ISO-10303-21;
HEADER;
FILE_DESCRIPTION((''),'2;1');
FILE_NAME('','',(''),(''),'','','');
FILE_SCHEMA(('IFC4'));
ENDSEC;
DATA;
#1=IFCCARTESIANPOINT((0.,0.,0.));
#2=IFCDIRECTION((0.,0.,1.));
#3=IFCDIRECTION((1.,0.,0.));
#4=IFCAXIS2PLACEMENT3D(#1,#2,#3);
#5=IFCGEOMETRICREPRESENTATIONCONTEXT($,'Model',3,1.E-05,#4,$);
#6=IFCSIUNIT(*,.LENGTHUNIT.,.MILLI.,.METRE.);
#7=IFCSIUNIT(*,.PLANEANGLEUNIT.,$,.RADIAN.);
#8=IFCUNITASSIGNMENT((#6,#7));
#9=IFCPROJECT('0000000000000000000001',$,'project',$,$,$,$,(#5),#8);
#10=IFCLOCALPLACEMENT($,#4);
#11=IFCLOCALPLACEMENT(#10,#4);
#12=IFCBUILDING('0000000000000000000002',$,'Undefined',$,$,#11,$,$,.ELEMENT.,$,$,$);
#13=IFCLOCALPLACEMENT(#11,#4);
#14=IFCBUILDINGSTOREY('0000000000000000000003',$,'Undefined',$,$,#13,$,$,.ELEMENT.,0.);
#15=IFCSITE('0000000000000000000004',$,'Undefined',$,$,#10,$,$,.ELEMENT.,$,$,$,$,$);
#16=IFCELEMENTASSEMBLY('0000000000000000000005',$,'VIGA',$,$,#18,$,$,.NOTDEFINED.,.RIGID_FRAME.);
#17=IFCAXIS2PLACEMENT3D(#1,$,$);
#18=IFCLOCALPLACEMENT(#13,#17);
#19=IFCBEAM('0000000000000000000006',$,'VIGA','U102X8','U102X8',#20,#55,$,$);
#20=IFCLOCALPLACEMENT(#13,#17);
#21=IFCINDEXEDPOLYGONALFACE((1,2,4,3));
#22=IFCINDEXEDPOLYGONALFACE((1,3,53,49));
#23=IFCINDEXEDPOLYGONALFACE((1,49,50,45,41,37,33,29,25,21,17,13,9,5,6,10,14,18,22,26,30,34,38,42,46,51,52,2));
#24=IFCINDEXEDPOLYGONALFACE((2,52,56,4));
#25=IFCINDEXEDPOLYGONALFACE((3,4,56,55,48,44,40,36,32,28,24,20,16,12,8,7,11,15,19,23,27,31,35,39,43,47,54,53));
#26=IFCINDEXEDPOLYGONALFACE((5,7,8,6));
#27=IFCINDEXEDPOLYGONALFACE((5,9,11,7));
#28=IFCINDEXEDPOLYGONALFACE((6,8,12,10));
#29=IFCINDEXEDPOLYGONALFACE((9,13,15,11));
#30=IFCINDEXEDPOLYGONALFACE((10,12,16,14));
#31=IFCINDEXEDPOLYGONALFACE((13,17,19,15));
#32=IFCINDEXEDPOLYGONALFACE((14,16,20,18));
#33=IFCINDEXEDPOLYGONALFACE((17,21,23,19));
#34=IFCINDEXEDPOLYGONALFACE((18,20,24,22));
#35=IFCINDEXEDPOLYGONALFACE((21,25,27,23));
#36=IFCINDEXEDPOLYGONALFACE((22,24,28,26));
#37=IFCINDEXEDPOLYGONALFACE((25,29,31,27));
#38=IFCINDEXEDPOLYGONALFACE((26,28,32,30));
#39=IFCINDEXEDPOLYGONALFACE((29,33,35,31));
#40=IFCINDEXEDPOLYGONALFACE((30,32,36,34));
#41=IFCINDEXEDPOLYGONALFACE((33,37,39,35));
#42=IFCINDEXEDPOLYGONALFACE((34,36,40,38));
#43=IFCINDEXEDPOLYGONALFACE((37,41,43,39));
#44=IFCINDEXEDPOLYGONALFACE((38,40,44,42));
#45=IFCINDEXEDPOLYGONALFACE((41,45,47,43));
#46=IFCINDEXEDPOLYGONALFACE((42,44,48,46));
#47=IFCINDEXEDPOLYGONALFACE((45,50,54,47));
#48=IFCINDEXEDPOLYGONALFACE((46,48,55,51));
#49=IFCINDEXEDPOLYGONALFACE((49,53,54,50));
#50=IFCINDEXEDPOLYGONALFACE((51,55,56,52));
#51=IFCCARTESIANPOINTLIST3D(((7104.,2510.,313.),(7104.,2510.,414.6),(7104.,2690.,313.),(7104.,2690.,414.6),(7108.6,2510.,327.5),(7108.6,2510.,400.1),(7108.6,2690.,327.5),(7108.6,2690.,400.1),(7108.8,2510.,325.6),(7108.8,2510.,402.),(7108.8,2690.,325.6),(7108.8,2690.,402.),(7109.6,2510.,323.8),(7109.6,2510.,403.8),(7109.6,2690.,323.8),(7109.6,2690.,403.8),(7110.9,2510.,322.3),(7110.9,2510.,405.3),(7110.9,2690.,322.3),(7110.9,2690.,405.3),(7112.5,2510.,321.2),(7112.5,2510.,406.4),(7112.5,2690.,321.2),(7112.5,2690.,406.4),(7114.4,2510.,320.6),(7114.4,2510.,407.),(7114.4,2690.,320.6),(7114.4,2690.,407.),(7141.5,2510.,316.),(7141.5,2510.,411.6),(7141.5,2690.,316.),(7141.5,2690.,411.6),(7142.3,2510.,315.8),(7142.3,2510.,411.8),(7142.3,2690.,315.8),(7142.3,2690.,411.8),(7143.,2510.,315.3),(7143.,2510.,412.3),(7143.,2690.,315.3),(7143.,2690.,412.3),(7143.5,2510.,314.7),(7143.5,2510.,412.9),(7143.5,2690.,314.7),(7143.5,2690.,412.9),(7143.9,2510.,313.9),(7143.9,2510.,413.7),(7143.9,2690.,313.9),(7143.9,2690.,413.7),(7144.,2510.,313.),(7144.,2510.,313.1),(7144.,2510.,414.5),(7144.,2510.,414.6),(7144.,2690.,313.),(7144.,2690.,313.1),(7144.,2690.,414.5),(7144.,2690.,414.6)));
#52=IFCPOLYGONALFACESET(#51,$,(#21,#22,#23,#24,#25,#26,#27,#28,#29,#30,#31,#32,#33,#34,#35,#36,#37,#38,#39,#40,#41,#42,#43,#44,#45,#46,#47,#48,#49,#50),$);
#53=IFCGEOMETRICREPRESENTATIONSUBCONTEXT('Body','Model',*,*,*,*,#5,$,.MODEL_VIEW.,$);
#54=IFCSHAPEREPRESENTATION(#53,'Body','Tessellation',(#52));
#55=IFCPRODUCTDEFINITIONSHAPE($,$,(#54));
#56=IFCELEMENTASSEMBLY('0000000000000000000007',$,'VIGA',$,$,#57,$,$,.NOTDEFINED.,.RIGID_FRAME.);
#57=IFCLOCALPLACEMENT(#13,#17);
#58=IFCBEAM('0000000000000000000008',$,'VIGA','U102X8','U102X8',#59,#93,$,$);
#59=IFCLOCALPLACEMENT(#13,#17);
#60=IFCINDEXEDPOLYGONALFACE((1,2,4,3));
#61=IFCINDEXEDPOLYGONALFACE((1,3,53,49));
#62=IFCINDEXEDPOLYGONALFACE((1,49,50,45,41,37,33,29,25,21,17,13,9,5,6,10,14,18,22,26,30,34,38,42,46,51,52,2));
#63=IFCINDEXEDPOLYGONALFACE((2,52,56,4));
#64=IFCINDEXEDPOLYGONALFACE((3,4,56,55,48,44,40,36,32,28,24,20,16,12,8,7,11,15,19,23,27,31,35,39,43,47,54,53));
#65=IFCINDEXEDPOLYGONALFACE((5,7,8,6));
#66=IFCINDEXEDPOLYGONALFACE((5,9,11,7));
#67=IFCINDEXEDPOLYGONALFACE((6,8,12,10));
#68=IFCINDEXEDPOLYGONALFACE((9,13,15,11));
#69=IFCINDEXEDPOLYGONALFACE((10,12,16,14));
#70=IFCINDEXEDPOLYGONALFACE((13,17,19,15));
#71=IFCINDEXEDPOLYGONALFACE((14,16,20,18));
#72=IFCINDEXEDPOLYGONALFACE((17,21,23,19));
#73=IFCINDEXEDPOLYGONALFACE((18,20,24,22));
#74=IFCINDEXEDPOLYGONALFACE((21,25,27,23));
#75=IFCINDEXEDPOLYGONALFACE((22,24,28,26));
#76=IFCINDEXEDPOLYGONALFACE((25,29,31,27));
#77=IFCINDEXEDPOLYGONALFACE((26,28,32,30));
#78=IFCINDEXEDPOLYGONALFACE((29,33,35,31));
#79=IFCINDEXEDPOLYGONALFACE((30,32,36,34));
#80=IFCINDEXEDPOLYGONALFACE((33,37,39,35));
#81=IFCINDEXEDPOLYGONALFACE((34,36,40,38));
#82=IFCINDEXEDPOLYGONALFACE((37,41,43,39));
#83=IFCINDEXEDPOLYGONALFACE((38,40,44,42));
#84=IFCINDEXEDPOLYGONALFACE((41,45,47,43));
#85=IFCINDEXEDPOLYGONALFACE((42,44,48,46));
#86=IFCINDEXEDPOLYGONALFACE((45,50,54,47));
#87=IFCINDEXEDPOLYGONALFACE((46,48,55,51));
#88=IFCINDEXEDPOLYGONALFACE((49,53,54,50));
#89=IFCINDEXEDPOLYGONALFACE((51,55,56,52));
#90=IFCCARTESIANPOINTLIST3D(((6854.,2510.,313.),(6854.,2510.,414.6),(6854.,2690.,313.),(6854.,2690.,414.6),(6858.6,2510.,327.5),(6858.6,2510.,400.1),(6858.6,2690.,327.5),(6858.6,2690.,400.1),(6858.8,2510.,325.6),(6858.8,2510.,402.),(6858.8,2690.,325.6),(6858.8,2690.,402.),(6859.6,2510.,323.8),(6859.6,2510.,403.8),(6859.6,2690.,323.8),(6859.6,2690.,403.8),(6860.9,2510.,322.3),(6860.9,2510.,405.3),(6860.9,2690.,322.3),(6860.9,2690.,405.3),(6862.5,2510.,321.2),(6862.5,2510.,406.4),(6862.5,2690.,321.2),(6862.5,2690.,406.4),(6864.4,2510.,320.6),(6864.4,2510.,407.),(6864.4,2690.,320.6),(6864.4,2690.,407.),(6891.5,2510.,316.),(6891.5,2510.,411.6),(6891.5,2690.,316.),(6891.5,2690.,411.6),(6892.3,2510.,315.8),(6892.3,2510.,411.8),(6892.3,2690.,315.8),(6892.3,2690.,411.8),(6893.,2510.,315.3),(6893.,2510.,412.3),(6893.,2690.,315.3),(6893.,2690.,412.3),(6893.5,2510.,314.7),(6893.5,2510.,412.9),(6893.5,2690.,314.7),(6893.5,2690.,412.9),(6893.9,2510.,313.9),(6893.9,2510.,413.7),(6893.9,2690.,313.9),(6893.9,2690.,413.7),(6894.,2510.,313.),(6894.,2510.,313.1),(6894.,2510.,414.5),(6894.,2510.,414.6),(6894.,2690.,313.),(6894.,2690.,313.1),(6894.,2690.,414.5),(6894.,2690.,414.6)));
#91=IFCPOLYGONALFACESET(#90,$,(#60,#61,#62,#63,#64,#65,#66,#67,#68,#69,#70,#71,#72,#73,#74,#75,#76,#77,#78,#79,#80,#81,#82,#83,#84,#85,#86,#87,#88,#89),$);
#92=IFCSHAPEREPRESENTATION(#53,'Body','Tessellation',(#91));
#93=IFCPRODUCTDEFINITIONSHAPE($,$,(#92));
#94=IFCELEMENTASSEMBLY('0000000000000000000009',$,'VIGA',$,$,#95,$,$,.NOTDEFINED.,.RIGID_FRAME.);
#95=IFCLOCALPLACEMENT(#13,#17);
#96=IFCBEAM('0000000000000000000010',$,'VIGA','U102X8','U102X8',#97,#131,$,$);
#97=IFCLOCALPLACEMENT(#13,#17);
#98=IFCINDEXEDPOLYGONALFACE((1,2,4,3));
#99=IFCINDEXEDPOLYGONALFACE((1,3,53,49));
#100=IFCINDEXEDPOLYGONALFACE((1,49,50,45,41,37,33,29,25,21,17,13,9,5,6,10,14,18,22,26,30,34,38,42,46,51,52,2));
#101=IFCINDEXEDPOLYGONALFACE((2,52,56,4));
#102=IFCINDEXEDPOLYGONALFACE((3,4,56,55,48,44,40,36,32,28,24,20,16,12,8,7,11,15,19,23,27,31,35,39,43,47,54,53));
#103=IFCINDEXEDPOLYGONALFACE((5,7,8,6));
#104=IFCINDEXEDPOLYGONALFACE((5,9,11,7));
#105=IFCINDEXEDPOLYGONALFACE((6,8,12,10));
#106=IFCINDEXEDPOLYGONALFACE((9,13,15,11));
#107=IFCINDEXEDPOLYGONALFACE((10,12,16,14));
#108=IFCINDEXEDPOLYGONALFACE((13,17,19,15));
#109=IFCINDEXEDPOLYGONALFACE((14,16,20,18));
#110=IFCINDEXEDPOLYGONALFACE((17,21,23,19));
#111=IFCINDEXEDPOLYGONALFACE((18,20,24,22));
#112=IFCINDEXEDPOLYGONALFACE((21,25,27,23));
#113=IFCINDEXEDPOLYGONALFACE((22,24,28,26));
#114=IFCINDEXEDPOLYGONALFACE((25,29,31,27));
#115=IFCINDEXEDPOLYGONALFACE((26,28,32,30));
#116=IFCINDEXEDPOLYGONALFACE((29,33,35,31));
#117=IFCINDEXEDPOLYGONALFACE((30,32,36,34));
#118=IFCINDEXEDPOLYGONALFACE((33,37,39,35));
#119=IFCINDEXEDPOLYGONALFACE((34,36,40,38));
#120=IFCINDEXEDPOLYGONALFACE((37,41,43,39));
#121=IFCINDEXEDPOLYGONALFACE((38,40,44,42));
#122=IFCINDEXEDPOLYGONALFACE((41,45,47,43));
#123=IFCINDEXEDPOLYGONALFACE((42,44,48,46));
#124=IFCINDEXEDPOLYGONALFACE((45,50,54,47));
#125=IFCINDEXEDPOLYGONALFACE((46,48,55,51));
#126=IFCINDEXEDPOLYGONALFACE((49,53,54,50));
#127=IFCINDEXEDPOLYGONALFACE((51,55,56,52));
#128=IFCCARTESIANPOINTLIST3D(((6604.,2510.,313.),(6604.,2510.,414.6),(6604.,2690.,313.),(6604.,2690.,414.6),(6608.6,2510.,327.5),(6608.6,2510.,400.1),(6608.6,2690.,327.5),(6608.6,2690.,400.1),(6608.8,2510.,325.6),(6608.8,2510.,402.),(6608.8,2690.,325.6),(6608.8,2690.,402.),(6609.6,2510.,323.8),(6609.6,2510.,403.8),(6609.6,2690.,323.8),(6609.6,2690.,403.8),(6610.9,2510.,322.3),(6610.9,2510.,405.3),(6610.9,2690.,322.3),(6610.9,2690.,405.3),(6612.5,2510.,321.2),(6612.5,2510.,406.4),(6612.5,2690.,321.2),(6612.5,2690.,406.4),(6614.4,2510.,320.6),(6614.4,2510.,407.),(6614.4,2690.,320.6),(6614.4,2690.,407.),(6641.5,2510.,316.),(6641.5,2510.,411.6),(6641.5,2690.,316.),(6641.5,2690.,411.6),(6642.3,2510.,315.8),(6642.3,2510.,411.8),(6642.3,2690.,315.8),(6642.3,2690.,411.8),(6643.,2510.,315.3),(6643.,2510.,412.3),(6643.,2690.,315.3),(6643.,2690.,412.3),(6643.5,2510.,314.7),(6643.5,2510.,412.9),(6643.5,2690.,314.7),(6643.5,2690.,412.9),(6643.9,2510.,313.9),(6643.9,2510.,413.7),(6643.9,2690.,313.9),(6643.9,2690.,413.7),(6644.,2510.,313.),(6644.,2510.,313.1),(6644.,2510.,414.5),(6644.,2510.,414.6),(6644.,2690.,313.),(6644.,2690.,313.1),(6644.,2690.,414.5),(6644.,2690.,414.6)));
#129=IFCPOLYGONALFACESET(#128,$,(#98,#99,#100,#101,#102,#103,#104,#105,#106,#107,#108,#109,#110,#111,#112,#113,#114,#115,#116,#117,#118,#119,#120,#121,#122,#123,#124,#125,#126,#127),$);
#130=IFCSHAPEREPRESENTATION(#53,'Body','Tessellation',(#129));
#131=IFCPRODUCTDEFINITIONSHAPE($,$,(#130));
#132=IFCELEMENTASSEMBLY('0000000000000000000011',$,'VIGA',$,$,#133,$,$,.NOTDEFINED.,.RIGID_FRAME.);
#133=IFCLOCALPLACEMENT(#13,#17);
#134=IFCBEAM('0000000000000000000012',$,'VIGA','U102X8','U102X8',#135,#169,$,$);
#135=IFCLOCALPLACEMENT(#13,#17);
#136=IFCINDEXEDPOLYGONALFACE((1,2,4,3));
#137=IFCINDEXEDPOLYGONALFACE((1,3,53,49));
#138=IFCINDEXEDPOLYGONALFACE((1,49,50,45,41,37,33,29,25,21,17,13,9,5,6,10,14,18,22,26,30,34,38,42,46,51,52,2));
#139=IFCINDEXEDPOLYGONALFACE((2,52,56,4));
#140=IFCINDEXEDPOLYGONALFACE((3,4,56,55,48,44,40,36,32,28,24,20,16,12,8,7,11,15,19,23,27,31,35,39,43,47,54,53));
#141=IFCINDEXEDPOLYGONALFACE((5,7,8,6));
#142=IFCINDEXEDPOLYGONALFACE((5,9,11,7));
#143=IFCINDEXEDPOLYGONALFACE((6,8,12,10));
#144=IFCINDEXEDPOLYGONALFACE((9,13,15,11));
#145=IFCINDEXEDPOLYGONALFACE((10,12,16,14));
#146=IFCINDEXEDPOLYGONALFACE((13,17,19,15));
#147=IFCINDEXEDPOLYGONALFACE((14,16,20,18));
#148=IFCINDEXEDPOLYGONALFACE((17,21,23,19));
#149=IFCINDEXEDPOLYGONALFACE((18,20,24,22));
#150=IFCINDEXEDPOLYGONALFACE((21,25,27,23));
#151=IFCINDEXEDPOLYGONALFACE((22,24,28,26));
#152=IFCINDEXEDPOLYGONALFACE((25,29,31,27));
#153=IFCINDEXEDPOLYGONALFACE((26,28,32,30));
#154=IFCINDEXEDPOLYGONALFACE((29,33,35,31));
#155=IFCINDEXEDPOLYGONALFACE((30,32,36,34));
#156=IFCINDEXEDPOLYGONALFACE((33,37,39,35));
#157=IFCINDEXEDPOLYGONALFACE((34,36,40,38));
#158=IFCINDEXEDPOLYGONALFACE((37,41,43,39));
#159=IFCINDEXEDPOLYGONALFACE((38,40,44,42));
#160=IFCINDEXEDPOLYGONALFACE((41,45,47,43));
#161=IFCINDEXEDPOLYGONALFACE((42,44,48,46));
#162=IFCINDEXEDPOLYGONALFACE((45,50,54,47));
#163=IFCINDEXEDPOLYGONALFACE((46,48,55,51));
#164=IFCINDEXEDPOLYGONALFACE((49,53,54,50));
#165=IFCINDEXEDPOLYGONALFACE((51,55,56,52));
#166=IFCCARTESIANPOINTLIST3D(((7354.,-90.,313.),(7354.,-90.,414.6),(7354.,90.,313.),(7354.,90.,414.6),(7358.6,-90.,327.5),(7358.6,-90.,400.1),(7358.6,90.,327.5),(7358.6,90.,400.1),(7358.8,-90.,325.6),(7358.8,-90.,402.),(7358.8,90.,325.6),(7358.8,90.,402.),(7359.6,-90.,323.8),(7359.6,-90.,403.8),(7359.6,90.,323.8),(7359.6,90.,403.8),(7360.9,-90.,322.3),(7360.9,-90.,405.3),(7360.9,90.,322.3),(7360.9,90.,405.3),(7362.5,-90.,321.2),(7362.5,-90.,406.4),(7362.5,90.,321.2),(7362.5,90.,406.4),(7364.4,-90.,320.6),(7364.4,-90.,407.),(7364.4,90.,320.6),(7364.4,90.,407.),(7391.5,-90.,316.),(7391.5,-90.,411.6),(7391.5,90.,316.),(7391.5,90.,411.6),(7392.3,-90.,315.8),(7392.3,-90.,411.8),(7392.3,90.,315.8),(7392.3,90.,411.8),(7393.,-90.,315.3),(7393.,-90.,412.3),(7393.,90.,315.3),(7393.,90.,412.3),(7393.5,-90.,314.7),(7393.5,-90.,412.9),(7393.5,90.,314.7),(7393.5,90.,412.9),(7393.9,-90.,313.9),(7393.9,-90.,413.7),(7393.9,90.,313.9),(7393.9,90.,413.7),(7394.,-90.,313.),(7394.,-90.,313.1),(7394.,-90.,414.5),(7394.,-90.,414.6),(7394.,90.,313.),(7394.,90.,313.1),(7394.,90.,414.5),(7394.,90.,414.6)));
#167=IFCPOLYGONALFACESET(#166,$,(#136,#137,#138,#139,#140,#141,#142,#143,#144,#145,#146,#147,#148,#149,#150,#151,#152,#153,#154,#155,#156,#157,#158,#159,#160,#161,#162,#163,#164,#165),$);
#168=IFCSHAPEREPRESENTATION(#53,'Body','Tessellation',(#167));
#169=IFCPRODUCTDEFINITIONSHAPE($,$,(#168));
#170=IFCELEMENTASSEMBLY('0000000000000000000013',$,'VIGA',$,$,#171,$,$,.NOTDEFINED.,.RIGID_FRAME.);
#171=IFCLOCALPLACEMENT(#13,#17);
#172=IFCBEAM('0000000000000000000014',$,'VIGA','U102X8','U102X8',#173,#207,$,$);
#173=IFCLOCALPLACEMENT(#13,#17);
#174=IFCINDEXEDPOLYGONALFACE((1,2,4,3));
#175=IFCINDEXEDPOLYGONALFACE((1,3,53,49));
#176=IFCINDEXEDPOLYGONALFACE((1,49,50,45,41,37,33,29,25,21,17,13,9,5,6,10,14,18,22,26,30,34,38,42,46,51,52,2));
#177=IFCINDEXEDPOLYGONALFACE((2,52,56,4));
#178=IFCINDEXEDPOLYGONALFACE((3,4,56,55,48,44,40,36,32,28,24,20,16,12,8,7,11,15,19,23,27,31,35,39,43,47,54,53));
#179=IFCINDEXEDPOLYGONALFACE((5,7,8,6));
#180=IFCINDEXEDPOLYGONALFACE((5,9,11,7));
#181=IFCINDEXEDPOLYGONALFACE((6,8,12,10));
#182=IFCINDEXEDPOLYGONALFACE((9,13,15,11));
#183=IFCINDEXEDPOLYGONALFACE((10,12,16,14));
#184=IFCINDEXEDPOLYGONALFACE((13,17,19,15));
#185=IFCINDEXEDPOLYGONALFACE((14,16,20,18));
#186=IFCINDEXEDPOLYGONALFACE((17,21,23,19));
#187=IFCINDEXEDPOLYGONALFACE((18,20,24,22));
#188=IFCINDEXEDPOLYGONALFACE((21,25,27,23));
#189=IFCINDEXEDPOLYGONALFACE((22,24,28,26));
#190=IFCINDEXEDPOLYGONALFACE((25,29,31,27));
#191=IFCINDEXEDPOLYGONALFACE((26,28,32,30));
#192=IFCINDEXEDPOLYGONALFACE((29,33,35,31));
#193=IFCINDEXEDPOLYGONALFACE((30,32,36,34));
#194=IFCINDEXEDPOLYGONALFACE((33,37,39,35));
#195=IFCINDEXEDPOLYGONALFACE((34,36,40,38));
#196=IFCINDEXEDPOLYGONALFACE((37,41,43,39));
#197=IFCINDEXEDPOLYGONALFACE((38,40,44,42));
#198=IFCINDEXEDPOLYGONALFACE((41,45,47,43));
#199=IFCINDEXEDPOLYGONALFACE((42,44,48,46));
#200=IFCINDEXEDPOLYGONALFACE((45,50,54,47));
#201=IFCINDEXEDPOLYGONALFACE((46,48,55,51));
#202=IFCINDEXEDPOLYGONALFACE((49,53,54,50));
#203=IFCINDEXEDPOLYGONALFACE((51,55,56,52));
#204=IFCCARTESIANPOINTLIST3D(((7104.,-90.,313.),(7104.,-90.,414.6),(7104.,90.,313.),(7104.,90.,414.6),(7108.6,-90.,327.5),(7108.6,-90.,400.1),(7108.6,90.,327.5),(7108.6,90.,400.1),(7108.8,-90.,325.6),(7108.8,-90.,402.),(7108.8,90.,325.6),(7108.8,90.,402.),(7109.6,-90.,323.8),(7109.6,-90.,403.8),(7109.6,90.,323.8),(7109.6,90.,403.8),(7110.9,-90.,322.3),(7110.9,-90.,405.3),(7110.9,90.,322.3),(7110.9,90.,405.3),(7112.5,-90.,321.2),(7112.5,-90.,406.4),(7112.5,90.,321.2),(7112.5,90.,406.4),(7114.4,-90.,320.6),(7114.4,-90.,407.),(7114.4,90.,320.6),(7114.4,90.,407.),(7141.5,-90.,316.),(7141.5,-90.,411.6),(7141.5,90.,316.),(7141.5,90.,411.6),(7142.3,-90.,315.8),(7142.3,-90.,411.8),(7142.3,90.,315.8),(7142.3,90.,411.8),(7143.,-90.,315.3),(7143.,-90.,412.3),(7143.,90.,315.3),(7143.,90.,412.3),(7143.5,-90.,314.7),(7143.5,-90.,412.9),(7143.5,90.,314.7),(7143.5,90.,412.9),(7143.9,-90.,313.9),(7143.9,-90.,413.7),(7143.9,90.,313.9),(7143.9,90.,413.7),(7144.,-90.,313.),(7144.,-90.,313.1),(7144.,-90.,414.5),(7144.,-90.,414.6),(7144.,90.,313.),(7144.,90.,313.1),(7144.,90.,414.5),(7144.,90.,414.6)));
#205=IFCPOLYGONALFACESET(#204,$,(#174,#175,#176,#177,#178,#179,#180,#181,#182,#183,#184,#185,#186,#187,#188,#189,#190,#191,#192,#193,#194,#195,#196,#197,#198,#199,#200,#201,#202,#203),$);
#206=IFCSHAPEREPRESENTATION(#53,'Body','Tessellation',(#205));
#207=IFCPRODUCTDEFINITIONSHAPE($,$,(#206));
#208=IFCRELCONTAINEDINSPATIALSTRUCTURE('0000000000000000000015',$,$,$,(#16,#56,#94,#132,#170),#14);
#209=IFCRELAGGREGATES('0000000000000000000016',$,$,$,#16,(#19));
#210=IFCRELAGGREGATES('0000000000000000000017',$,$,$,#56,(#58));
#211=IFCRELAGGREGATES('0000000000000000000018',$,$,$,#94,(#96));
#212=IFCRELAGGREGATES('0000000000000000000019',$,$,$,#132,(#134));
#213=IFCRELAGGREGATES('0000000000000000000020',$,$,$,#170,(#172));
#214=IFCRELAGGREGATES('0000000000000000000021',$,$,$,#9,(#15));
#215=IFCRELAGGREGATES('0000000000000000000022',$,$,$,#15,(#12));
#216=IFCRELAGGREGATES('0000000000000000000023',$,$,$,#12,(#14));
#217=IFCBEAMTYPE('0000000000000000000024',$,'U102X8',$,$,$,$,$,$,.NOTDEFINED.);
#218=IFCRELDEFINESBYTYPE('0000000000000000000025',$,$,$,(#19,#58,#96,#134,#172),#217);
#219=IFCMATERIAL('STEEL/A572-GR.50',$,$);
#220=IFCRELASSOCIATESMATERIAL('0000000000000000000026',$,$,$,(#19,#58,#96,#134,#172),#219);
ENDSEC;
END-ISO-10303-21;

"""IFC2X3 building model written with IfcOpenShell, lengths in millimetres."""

from ifc_helpers import new_model, si_unit, frame, origin_with_axes, origin_2d_with_axis, place, context, subcontext, project, spatial, u_section, extrude, material, type_object, element, aggregate, save


model = new_model("IFC2X3")

# Units and contexts
model_context = context("Model", 3, precision=1e-05, world=origin_with_axes())
body_context = subcontext(model_context, "Body", "Model", "MODEL_VIEW")
ifc_project = project(units=[si_unit("LENGTHUNIT", "METRE", prefix="MILLI"), si_unit("PLANEANGLEUNIT", "RADIAN")], contexts=[model_context])

# Site, building, storey
site_placement = place(None, origin_with_axes())
site = spatial("IfcSite", under=ifc_project, at=site_placement, Name="Undefined", CompositionType="ELEMENT")
building_placement = place(site_placement, origin_with_axes())
building = spatial("IfcBuilding", under=site, at=building_placement, Name="Undefined", CompositionType="ELEMENT")
storey_placement = place(building_placement, origin_with_axes())
storey = spatial("IfcBuildingStorey", under=building, at=storey_placement, Name="Undefined", CompositionType="ELEMENT", Elevation=0.0)

# Element assemblies, beams
ifc_material_1 = material(Name="STEEL/A572-GR.50")
beam_type_1 = type_object("IfcBeamType", Name="U102X8", PredefinedType="NOTDEFINED")
assembly_1_placement = place(storey_placement, origin_with_axes())
assembly_1 = element("IfcElementAssembly", 1, at=assembly_1_placement, inside=storey, Name="VIGA", AssemblyPlace="NOTDEFINED", PredefinedType="RIGID_FRAME")
beam_1_placement = place(assembly_1_placement, frame((7124.0, 2510.0, 363.8), z_axis=(0.0, 0.0, 1.0), x_axis=(0.0, 1.0, 0.0)))
beam_1 = element("IfcBeam", 2, at=beam_1_placement, type_object=beam_type_1, material=ifc_material_1, Name="VIGA", Description="U102X8", ObjectType="U102X8", context=body_context, shape_type="SweptSolid", body=[
    extrude(u_section(Depth=101.6, FlangeWidth=40.0, WebThickness=4.6, FlangeThickness=6.0, FilletRadius=7.0, EdgeRadius=3.0, FlangeSlope=0.16839, at=origin_2d_with_axis()), frame((180.0, 0.0, 0.0), z_axis=(-1.0, 0.0, 0.0), x_axis=(0.0, -1.0, 0.0)), (0.0, 0.0, 1.0), 180.0),
])
aggregate(assembly_1, [beam_1])
assembly_2_placement = place(storey_placement, origin_with_axes())
assembly_2 = element("IfcElementAssembly", 3, at=assembly_2_placement, inside=storey, Name="VIGA", AssemblyPlace="NOTDEFINED", PredefinedType="RIGID_FRAME")
beam_2_placement = place(assembly_2_placement, frame((6874.0, 2510.0, 363.8), z_axis=(0.0, 0.0, 1.0), x_axis=(0.0, 1.0, 0.0)))
beam_2 = element("IfcBeam", 4, at=beam_2_placement, type_object=beam_type_1, material=ifc_material_1, Name="VIGA", Description="U102X8", ObjectType="U102X8", context=body_context, shape_type="SweptSolid", body=[
    extrude(u_section(Depth=101.6, FlangeWidth=40.0, WebThickness=4.6, FlangeThickness=6.0, FilletRadius=7.0, EdgeRadius=3.0, FlangeSlope=0.16839, at=origin_2d_with_axis()), frame((180.0, 0.0, 0.0), z_axis=(-1.0, 0.0, 0.0), x_axis=(0.0, -1.0, 0.0)), (0.0, 0.0, 1.0), 180.0),
])
aggregate(assembly_2, [beam_2])
assembly_3_placement = place(storey_placement, origin_with_axes())
assembly_3 = element("IfcElementAssembly", 5, at=assembly_3_placement, inside=storey, Name="VIGA", AssemblyPlace="NOTDEFINED", PredefinedType="RIGID_FRAME")
beam_3_placement = place(assembly_3_placement, frame((6624.0, 2510.0, 363.8), z_axis=(0.0, 0.0, 1.0), x_axis=(0.0, 1.0, 0.0)))
beam_3 = element("IfcBeam", 6, at=beam_3_placement, type_object=beam_type_1, material=ifc_material_1, Name="VIGA", Description="U102X8", ObjectType="U102X8", context=body_context, shape_type="SweptSolid", body=[
    extrude(u_section(Depth=101.6, FlangeWidth=40.0, WebThickness=4.6, FlangeThickness=6.0, FilletRadius=7.0, EdgeRadius=3.0, FlangeSlope=0.16839, at=origin_2d_with_axis()), frame((180.0, 0.0, 0.0), z_axis=(-1.0, 0.0, 0.0), x_axis=(0.0, -1.0, 0.0)), (0.0, 0.0, 1.0), 180.0),
])
aggregate(assembly_3, [beam_3])
assembly_4_placement = place(storey_placement, origin_with_axes())
assembly_4 = element("IfcElementAssembly", 7, at=assembly_4_placement, inside=storey, Name="VIGA", AssemblyPlace="NOTDEFINED", PredefinedType="RIGID_FRAME")
beam_4_placement = place(assembly_4_placement, frame((7374.0, -90.0, 363.8), z_axis=(0.0, 0.0, 1.0), x_axis=(0.0, 1.0, 0.0)))
beam_4 = element("IfcBeam", 8, at=beam_4_placement, type_object=beam_type_1, material=ifc_material_1, Name="VIGA", Description="U102X8", ObjectType="U102X8", context=body_context, shape_type="SweptSolid", body=[
    extrude(u_section(Depth=101.6, FlangeWidth=40.0, WebThickness=4.6, FlangeThickness=6.0, FilletRadius=7.0, EdgeRadius=3.0, FlangeSlope=0.16839, at=origin_2d_with_axis()), frame((180.0, 0.0, 0.0), z_axis=(-1.0, 0.0, 0.0), x_axis=(0.0, -1.0, 0.0)), (0.0, 0.0, 1.0), 180.0),
])
aggregate(assembly_4, [beam_4])
assembly_5_placement = place(storey_placement, origin_with_axes())
assembly_5 = element("IfcElementAssembly", 9, at=assembly_5_placement, inside=storey, Name="VIGA", AssemblyPlace="NOTDEFINED", PredefinedType="RIGID_FRAME")
beam_5_placement = place(assembly_5_placement, frame((7124.0, -90.0, 363.8), z_axis=(0.0, 0.0, 1.0), x_axis=(0.0, 1.0, 0.0)))
beam_5 = element("IfcBeam", 10, at=beam_5_placement, type_object=beam_type_1, material=ifc_material_1, Name="VIGA", Description="U102X8", ObjectType="U102X8", context=body_context, shape_type="SweptSolid", body=[
    extrude(u_section(Depth=101.6, FlangeWidth=40.0, WebThickness=4.6, FlangeThickness=6.0, FilletRadius=7.0, EdgeRadius=3.0, FlangeSlope=0.16839, at=origin_2d_with_axis()), frame((180.0, 0.0, 0.0), z_axis=(-1.0, 0.0, 0.0), x_axis=(0.0, -1.0, 0.0)), (0.0, 0.0, 1.0), 180.0),
])
aggregate(assembly_5, [beam_5])

save(model, "model.ifc")
